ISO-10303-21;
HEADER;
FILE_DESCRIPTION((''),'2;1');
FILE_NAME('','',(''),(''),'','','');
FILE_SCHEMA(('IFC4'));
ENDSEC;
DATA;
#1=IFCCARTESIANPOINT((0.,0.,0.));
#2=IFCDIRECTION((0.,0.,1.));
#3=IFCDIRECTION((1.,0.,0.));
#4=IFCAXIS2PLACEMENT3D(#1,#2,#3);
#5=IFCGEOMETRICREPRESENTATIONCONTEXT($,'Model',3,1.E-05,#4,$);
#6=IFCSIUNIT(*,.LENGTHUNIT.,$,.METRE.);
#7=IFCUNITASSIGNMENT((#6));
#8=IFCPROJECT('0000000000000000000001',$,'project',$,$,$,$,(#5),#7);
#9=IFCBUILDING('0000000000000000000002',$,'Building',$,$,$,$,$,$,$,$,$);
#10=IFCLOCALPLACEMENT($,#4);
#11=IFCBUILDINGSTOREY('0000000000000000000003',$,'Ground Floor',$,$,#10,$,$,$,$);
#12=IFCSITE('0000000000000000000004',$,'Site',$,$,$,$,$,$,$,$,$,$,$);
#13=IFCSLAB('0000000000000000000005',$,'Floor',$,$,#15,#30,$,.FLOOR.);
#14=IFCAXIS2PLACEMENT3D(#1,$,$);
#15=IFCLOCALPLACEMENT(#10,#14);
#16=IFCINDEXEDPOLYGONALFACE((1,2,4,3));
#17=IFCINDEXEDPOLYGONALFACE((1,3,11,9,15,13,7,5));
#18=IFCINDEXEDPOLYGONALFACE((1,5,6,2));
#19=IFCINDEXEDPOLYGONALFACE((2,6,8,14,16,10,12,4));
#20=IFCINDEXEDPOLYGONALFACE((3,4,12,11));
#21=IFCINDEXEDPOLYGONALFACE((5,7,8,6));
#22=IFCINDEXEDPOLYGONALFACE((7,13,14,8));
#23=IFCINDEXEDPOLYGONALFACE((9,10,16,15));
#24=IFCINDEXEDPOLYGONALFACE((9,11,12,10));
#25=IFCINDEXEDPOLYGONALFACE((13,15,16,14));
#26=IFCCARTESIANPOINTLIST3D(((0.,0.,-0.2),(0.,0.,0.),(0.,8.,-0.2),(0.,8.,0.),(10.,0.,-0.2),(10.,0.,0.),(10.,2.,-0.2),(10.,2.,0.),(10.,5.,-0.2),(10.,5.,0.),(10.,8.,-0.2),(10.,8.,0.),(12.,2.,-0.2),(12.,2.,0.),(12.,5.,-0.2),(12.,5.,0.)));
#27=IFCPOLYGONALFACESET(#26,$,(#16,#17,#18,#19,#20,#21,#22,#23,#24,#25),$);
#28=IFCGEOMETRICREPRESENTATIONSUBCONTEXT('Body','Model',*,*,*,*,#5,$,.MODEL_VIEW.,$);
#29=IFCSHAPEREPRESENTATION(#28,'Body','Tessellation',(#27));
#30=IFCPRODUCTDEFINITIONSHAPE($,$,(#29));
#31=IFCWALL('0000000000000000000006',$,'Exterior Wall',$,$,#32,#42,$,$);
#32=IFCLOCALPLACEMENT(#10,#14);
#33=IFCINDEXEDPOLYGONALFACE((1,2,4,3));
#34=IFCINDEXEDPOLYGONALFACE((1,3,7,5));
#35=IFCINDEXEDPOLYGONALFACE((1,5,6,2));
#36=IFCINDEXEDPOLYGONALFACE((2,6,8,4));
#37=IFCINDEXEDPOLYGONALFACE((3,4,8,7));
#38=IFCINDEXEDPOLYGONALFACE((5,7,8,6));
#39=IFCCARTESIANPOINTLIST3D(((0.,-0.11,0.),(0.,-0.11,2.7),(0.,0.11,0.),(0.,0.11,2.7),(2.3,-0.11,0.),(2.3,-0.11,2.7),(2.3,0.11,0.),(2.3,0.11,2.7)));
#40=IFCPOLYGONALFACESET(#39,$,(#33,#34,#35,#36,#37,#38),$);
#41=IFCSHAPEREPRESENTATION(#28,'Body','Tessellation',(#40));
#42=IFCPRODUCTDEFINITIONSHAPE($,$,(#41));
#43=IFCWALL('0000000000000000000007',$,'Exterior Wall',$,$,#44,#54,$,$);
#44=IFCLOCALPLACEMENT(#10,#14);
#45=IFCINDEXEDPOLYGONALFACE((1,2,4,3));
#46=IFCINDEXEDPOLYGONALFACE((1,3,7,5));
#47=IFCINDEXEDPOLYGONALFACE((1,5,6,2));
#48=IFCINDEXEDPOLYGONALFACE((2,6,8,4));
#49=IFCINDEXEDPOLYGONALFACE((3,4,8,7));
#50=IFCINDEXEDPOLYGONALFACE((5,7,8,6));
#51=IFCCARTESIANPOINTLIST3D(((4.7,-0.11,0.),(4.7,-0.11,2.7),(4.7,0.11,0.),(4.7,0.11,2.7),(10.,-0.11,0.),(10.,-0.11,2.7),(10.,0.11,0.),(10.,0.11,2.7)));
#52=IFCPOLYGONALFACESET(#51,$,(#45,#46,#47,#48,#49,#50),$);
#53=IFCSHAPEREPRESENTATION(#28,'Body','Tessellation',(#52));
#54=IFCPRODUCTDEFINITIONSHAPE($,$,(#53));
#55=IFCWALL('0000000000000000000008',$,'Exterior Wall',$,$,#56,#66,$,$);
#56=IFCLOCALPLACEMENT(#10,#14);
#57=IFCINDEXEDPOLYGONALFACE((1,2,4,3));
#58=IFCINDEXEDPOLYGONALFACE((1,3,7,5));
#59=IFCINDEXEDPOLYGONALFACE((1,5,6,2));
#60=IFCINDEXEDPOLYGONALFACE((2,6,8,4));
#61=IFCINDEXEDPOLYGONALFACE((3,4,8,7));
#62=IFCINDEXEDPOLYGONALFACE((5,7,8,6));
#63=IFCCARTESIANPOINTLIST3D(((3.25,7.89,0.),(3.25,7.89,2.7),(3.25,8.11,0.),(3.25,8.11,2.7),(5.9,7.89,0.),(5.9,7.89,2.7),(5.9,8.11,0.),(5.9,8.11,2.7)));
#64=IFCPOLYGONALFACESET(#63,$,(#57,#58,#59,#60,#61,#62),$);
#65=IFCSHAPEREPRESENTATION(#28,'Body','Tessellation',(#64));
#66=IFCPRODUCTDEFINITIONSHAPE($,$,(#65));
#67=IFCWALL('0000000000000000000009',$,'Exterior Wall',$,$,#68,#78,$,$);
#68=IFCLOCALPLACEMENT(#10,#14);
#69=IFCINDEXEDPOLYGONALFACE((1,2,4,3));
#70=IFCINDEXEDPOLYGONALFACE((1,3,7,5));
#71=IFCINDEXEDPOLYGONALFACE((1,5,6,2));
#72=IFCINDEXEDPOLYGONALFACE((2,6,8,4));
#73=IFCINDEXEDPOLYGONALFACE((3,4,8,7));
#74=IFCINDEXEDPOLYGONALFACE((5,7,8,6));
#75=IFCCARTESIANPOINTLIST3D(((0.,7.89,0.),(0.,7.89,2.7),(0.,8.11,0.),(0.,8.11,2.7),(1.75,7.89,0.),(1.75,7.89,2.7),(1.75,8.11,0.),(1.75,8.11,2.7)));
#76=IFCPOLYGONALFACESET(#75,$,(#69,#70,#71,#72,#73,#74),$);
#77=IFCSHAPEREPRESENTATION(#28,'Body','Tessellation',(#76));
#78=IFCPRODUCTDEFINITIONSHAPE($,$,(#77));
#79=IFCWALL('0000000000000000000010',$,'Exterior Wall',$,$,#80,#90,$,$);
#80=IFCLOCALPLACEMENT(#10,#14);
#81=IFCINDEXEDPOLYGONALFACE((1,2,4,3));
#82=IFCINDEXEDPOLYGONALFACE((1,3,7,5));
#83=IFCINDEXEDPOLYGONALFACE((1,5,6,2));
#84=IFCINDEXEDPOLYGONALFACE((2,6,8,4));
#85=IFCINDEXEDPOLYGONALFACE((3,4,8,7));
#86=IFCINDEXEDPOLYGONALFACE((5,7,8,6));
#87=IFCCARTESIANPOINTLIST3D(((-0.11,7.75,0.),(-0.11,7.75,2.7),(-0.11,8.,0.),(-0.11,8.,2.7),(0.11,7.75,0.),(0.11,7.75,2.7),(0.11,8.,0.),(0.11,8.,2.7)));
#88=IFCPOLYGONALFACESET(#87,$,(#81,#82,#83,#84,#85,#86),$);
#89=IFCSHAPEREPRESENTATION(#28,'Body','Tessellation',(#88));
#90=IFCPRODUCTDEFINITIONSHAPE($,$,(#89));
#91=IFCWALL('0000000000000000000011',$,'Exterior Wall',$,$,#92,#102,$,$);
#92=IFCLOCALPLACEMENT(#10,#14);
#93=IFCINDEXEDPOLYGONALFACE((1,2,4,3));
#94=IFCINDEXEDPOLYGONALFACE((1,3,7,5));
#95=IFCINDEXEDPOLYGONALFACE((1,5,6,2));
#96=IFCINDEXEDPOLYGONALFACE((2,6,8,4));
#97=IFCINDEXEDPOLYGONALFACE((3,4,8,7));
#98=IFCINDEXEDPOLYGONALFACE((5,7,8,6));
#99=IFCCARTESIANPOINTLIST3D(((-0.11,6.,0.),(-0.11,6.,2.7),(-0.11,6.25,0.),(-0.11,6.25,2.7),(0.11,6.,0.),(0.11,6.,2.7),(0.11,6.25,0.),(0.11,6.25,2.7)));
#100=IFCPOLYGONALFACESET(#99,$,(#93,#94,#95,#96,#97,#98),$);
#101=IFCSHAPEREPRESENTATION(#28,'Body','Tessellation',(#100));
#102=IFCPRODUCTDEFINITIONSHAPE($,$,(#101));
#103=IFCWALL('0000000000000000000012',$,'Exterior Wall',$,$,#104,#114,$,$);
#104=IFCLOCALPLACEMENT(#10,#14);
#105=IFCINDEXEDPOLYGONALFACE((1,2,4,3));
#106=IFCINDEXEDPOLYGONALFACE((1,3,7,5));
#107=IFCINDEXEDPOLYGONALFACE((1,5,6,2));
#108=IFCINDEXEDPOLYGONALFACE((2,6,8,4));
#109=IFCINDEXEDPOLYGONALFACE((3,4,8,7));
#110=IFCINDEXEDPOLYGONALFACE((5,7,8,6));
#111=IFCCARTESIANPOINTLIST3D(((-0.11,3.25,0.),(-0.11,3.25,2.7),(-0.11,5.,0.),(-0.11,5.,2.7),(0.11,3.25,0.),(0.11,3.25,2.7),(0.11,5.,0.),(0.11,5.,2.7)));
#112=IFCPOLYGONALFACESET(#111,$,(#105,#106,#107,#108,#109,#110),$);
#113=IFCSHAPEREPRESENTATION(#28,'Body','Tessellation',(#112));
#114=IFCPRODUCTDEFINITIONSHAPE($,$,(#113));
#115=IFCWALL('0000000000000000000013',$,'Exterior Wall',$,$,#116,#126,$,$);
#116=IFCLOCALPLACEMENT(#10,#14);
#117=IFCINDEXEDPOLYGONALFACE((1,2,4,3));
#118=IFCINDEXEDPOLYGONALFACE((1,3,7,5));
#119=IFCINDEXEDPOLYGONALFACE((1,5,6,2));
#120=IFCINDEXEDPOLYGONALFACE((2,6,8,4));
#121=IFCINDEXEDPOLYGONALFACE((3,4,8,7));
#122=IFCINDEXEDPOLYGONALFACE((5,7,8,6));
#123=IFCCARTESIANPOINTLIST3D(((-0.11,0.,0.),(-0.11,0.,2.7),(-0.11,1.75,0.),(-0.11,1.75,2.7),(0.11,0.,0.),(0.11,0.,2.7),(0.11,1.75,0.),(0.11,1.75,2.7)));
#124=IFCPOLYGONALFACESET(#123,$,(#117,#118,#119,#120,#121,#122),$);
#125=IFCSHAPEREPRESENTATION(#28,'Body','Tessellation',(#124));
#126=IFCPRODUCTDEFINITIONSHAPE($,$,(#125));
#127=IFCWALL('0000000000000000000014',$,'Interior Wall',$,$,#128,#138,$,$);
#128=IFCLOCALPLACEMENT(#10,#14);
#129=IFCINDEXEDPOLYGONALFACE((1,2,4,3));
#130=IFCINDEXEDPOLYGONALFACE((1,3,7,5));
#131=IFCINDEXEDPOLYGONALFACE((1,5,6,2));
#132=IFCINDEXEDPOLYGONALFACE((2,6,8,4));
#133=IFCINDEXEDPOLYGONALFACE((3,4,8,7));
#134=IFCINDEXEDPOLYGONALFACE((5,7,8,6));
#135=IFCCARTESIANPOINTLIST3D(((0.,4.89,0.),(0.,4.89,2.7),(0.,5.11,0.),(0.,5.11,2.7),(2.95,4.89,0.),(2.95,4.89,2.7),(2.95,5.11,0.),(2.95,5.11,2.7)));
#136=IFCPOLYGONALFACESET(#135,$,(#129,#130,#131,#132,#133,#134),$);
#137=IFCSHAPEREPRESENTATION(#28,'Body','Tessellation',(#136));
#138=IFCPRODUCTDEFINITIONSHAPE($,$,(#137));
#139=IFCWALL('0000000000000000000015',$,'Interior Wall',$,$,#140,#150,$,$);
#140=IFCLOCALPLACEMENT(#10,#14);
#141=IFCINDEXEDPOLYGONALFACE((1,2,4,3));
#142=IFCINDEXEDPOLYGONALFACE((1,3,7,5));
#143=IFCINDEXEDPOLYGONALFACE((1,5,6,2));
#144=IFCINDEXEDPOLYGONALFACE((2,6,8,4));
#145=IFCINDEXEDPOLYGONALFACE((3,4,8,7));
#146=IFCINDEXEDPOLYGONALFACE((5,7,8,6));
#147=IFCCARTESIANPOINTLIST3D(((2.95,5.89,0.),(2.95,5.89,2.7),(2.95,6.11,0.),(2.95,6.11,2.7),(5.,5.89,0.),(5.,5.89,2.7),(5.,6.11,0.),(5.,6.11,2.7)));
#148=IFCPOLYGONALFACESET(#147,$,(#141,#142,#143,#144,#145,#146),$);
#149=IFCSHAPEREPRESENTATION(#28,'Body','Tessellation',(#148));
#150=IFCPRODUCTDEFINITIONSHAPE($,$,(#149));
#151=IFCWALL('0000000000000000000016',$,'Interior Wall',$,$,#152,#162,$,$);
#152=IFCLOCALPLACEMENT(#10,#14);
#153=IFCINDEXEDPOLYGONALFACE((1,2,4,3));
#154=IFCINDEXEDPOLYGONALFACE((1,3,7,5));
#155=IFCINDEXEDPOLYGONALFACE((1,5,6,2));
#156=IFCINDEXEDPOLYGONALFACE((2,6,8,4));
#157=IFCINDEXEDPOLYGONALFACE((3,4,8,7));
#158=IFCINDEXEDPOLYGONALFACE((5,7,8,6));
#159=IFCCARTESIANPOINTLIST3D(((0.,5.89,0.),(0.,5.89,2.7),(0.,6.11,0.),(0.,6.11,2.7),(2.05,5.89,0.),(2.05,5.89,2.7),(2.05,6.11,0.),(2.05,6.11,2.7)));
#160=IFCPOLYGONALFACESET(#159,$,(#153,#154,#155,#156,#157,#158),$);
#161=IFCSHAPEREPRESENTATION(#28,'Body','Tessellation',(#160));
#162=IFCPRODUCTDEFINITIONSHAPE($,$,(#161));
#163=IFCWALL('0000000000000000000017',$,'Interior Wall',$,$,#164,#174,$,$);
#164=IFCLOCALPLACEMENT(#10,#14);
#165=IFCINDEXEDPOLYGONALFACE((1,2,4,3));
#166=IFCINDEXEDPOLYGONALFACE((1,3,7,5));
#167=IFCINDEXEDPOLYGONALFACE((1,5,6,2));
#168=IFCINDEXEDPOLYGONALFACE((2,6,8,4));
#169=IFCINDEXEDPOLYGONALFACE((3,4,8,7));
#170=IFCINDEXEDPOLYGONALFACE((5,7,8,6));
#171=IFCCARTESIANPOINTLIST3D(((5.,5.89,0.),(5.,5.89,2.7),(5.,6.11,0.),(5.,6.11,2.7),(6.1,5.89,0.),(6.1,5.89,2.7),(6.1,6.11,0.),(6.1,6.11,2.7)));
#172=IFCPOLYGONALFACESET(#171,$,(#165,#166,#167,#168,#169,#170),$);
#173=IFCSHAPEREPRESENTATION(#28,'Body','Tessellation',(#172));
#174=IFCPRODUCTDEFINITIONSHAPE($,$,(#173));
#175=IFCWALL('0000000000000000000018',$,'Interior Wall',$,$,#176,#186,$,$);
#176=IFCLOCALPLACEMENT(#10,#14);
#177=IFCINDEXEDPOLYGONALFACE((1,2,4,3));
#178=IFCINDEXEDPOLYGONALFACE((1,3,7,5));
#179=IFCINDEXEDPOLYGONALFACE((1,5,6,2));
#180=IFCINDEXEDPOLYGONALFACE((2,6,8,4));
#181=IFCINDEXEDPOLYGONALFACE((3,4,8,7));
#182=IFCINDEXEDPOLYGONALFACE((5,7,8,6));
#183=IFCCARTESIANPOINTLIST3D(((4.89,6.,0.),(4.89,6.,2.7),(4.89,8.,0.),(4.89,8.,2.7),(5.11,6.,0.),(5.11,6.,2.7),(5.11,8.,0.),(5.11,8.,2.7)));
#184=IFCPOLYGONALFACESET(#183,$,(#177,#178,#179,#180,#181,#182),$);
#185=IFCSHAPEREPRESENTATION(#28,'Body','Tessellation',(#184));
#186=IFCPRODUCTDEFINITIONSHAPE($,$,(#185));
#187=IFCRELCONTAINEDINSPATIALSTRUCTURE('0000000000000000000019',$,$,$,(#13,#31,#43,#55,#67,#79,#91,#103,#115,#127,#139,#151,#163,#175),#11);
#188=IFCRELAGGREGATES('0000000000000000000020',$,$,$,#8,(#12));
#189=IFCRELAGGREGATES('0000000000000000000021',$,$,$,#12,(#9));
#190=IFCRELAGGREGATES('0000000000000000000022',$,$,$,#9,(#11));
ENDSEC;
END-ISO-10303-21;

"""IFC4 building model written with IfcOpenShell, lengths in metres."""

from ifc_helpers import new_model, si_unit, frame, origin_with_axes, place, context, subcontext, project, spatial, indexed_curve, outline, extrude, element, save


model = new_model("IFC4")

# Units and contexts
model_context = context("Model", 3, precision=1e-05, world=origin_with_axes())
body_context = subcontext(model_context, "Body", "Model", "MODEL_VIEW")
ifc_project = project(units=[si_unit("LENGTHUNIT", "METRE")], contexts=[model_context])

# Site, building, storey
site = spatial("IfcSite", under=ifc_project, Name="Site")
building = spatial("IfcBuilding", under=site, Name="Building")
storey_placement = place(None, origin_with_axes())
storey = spatial("IfcBuildingStorey", under=building, at=storey_placement, Name="Ground Floor")

# Slab
slab_placement = place(storey_placement, frame((0.0, 0.0, -0.2), z_axis=(0.0, 0.0, 1.0), x_axis=(1.0, 0.0, 0.0)))
element("IfcSlab", 1, at=slab_placement, inside=storey, Name="Floor", PredefinedType="FLOOR", context=body_context, shape_type="SweptSolid", body=[
    extrude(outline(indexed_curve([(0.0, 0.0), (10.0, 0.0), (10.0, 2.0), (12.0, 2.0), (12.0, 5.0), (10.0, 5.0), (10.0, 8.0), (0.0, 8.0)])), None, (0.0, 0.0, 1.0), 0.2),
])

# Walls
wall_1_placement = place(storey_placement, origin_with_axes())
element("IfcWall", 2, at=wall_1_placement, inside=storey, Name="Exterior Wall", context=body_context, shape_type="SweptSolid", body=[
    extrude(outline(indexed_curve([(0.0, 0.0), (0.0, 0.22), (2.3, 0.22), (2.3, 0.0), (0.0, 0.0)], self_intersect=False)), frame((0.0, -0.11, 0.0), z_axis=(0.0, 0.0, 1.0), x_axis=(1.0, 0.0, 0.0)), (0.0, 0.0, 1.0), 2.7),
])
wall_2_placement = place(storey_placement, frame((4.7, 0.0, 0.0), z_axis=(0.0, 0.0, 1.0), x_axis=(1.0, 0.0, 0.0)))
element("IfcWall", 3, at=wall_2_placement, inside=storey, Name="Exterior Wall", context=body_context, shape_type="SweptSolid", body=[
    extrude(outline(indexed_curve([(0.0, 0.0), (0.0, 0.22), (5.3, 0.22), (5.3, 0.0), (0.0, 0.0)], self_intersect=False)), frame((0.0, -0.11, 0.0), z_axis=(0.0, 0.0, 1.0), x_axis=(1.0, 0.0, 0.0)), (0.0, 0.0, 1.0), 2.7),
])
wall_3_placement = place(storey_placement, frame((5.9, 8.0, 0.0), z_axis=(0.0, 0.0, 1.0), x_axis=(-1.0, 0.0, 0.0)))
element("IfcWall", 4, at=wall_3_placement, inside=storey, Name="Exterior Wall", context=body_context, shape_type="SweptSolid", body=[
    extrude(outline(indexed_curve([(0.0, 0.0), (0.0, 0.22), (2.65, 0.22), (2.65, 0.0), (0.0, 0.0)], self_intersect=False)), frame((0.0, -0.11, 0.0), z_axis=(0.0, 0.0, 1.0), x_axis=(1.0, 0.0, 0.0)), (0.0, 0.0, 1.0), 2.7),
])
wall_4_placement = place(storey_placement, frame((1.75, 8.0, 0.0), z_axis=(0.0, 0.0, 1.0), x_axis=(-1.0, 0.0, 0.0)))
element("IfcWall", 5, at=wall_4_placement, inside=storey, Name="Exterior Wall", context=body_context, shape_type="SweptSolid", body=[
    extrude(outline(indexed_curve([(0.0, 0.0), (0.0, 0.22), (1.75, 0.22), (1.75, 0.0), (0.0, 0.0)], self_intersect=False)), frame((0.0, -0.11, 0.0), z_axis=(0.0, 0.0, 1.0), x_axis=(1.0, 0.0, 0.0)), (0.0, 0.0, 1.0), 2.7),
])
for number, where, z_axis, x_axis, name in (
    (6, (0.0, 8.0, 0.0), (0.0, 0.0, 1.0), (0.0, -1.0, 0.0), "Exterior Wall"),
    (7, (0.0, 6.25, 0.0), (0.0, 0.0, 1.0), (0.0, -1.0, 0.0), "Exterior Wall"),
):
    element("IfcWall", number, at=place(storey_placement, frame(where, z_axis=z_axis, x_axis=x_axis)), inside=storey, Name=name, context=body_context, shape_type="SweptSolid", body=[
        extrude(outline(indexed_curve([(0.0, 0.0), (0.0, 0.22), (0.25, 0.22), (0.25, 0.0), (0.0, 0.0)], self_intersect=False)), frame((0.0, -0.11, 0.0), z_axis=(0.0, 0.0, 1.0), x_axis=(1.0, 0.0, 0.0)), (0.0, 0.0, 1.0), 2.7),
    ])
for number, where, z_axis, x_axis, name in (
    (8, (0.0, 5.0, 0.0), (0.0, 0.0, 1.0), (0.0, -1.0, 0.0), "Exterior Wall"),
    (9, (0.0, 1.75, 0.0), (0.0, 0.0, 1.0), (0.0, -1.0, 0.0), "Exterior Wall"),
):
    element("IfcWall", number, at=place(storey_placement, frame(where, z_axis=z_axis, x_axis=x_axis)), inside=storey, Name=name, context=body_context, shape_type="SweptSolid", body=[
        extrude(outline(indexed_curve([(0.0, 0.0), (0.0, 0.22), (1.75, 0.22), (1.75, 0.0), (0.0, 0.0)], self_intersect=False)), frame((0.0, -0.11, 0.0), z_axis=(0.0, 0.0, 1.0), x_axis=(1.0, 0.0, 0.0)), (0.0, 0.0, 1.0), 2.7),
    ])
wall_5_placement = place(storey_placement, frame((2.95, 5.0, 0.0), z_axis=(0.0, 0.0, 1.0), x_axis=(-1.0, 0.0, 0.0)))
element("IfcWall", 10, at=wall_5_placement, inside=storey, Name="Interior Wall", context=body_context, shape_type="SweptSolid", body=[
    extrude(outline(indexed_curve([(0.0, 0.0), (0.0, 0.22), (2.95, 0.22), (2.95, 0.0), (0.0, 0.0)], self_intersect=False)), frame((0.0, -0.11, 0.0), z_axis=(0.0, 0.0, 1.0), x_axis=(1.0, 0.0, 0.0)), (0.0, 0.0, 1.0), 2.7),
])
for number, where, z_axis, x_axis, name in (
    (11, (5.0, 6.0, 0.0), (0.0, 0.0, 1.0), (-1.0, 0.0, 0.0), "Interior Wall"),
    (12, (2.05, 6.0, 0.0), (0.0, 0.0, 1.0), (-1.0, 0.0, 0.0), "Interior Wall"),
):
    element("IfcWall", number, at=place(storey_placement, frame(where, z_axis=z_axis, x_axis=x_axis)), inside=storey, Name=name, context=body_context, shape_type="SweptSolid", body=[
        extrude(outline(indexed_curve([(0.0, 0.0), (0.0, 0.22), (2.05, 0.22), (2.05, 0.0), (0.0, 0.0)], self_intersect=False)), frame((0.0, -0.11, 0.0), z_axis=(0.0, 0.0, 1.0), x_axis=(1.0, 0.0, 0.0)), (0.0, 0.0, 1.0), 2.7),
    ])
wall_6_placement = place(storey_placement, frame((6.1, 6.0, 0.0), z_axis=(0.0, 0.0, 1.0), x_axis=(-1.0, 0.0, 0.0)))
element("IfcWall", 13, at=wall_6_placement, inside=storey, Name="Interior Wall", context=body_context, shape_type="SweptSolid", body=[
    extrude(outline(indexed_curve([(0.0, 0.0), (0.0, 0.22), (1.1, 0.22), (1.1, 0.0), (0.0, 0.0)], self_intersect=False)), frame((0.0, -0.11, 0.0), z_axis=(0.0, 0.0, 1.0), x_axis=(1.0, 0.0, 0.0)), (0.0, 0.0, 1.0), 2.7),
])
wall_7_placement = place(storey_placement, frame((5.0, 6.0, 0.0), z_axis=(0.0, 0.0, 1.0), x_axis=(0.0, 1.0, 0.0)))
element("IfcWall", 14, at=wall_7_placement, inside=storey, Name="Interior Wall", context=body_context, shape_type="SweptSolid", body=[
    extrude(outline(indexed_curve([(0.0, 0.0), (0.0, 0.22), (2.0, 0.22), (2.0, 0.0), (0.0, 0.0)], self_intersect=False)), frame((0.0, -0.11, 0.0), z_axis=(0.0, 0.0, 1.0), x_axis=(1.0, 0.0, 0.0)), (0.0, 0.0, 1.0), 2.7),
])

save(model, "model.ifc")
